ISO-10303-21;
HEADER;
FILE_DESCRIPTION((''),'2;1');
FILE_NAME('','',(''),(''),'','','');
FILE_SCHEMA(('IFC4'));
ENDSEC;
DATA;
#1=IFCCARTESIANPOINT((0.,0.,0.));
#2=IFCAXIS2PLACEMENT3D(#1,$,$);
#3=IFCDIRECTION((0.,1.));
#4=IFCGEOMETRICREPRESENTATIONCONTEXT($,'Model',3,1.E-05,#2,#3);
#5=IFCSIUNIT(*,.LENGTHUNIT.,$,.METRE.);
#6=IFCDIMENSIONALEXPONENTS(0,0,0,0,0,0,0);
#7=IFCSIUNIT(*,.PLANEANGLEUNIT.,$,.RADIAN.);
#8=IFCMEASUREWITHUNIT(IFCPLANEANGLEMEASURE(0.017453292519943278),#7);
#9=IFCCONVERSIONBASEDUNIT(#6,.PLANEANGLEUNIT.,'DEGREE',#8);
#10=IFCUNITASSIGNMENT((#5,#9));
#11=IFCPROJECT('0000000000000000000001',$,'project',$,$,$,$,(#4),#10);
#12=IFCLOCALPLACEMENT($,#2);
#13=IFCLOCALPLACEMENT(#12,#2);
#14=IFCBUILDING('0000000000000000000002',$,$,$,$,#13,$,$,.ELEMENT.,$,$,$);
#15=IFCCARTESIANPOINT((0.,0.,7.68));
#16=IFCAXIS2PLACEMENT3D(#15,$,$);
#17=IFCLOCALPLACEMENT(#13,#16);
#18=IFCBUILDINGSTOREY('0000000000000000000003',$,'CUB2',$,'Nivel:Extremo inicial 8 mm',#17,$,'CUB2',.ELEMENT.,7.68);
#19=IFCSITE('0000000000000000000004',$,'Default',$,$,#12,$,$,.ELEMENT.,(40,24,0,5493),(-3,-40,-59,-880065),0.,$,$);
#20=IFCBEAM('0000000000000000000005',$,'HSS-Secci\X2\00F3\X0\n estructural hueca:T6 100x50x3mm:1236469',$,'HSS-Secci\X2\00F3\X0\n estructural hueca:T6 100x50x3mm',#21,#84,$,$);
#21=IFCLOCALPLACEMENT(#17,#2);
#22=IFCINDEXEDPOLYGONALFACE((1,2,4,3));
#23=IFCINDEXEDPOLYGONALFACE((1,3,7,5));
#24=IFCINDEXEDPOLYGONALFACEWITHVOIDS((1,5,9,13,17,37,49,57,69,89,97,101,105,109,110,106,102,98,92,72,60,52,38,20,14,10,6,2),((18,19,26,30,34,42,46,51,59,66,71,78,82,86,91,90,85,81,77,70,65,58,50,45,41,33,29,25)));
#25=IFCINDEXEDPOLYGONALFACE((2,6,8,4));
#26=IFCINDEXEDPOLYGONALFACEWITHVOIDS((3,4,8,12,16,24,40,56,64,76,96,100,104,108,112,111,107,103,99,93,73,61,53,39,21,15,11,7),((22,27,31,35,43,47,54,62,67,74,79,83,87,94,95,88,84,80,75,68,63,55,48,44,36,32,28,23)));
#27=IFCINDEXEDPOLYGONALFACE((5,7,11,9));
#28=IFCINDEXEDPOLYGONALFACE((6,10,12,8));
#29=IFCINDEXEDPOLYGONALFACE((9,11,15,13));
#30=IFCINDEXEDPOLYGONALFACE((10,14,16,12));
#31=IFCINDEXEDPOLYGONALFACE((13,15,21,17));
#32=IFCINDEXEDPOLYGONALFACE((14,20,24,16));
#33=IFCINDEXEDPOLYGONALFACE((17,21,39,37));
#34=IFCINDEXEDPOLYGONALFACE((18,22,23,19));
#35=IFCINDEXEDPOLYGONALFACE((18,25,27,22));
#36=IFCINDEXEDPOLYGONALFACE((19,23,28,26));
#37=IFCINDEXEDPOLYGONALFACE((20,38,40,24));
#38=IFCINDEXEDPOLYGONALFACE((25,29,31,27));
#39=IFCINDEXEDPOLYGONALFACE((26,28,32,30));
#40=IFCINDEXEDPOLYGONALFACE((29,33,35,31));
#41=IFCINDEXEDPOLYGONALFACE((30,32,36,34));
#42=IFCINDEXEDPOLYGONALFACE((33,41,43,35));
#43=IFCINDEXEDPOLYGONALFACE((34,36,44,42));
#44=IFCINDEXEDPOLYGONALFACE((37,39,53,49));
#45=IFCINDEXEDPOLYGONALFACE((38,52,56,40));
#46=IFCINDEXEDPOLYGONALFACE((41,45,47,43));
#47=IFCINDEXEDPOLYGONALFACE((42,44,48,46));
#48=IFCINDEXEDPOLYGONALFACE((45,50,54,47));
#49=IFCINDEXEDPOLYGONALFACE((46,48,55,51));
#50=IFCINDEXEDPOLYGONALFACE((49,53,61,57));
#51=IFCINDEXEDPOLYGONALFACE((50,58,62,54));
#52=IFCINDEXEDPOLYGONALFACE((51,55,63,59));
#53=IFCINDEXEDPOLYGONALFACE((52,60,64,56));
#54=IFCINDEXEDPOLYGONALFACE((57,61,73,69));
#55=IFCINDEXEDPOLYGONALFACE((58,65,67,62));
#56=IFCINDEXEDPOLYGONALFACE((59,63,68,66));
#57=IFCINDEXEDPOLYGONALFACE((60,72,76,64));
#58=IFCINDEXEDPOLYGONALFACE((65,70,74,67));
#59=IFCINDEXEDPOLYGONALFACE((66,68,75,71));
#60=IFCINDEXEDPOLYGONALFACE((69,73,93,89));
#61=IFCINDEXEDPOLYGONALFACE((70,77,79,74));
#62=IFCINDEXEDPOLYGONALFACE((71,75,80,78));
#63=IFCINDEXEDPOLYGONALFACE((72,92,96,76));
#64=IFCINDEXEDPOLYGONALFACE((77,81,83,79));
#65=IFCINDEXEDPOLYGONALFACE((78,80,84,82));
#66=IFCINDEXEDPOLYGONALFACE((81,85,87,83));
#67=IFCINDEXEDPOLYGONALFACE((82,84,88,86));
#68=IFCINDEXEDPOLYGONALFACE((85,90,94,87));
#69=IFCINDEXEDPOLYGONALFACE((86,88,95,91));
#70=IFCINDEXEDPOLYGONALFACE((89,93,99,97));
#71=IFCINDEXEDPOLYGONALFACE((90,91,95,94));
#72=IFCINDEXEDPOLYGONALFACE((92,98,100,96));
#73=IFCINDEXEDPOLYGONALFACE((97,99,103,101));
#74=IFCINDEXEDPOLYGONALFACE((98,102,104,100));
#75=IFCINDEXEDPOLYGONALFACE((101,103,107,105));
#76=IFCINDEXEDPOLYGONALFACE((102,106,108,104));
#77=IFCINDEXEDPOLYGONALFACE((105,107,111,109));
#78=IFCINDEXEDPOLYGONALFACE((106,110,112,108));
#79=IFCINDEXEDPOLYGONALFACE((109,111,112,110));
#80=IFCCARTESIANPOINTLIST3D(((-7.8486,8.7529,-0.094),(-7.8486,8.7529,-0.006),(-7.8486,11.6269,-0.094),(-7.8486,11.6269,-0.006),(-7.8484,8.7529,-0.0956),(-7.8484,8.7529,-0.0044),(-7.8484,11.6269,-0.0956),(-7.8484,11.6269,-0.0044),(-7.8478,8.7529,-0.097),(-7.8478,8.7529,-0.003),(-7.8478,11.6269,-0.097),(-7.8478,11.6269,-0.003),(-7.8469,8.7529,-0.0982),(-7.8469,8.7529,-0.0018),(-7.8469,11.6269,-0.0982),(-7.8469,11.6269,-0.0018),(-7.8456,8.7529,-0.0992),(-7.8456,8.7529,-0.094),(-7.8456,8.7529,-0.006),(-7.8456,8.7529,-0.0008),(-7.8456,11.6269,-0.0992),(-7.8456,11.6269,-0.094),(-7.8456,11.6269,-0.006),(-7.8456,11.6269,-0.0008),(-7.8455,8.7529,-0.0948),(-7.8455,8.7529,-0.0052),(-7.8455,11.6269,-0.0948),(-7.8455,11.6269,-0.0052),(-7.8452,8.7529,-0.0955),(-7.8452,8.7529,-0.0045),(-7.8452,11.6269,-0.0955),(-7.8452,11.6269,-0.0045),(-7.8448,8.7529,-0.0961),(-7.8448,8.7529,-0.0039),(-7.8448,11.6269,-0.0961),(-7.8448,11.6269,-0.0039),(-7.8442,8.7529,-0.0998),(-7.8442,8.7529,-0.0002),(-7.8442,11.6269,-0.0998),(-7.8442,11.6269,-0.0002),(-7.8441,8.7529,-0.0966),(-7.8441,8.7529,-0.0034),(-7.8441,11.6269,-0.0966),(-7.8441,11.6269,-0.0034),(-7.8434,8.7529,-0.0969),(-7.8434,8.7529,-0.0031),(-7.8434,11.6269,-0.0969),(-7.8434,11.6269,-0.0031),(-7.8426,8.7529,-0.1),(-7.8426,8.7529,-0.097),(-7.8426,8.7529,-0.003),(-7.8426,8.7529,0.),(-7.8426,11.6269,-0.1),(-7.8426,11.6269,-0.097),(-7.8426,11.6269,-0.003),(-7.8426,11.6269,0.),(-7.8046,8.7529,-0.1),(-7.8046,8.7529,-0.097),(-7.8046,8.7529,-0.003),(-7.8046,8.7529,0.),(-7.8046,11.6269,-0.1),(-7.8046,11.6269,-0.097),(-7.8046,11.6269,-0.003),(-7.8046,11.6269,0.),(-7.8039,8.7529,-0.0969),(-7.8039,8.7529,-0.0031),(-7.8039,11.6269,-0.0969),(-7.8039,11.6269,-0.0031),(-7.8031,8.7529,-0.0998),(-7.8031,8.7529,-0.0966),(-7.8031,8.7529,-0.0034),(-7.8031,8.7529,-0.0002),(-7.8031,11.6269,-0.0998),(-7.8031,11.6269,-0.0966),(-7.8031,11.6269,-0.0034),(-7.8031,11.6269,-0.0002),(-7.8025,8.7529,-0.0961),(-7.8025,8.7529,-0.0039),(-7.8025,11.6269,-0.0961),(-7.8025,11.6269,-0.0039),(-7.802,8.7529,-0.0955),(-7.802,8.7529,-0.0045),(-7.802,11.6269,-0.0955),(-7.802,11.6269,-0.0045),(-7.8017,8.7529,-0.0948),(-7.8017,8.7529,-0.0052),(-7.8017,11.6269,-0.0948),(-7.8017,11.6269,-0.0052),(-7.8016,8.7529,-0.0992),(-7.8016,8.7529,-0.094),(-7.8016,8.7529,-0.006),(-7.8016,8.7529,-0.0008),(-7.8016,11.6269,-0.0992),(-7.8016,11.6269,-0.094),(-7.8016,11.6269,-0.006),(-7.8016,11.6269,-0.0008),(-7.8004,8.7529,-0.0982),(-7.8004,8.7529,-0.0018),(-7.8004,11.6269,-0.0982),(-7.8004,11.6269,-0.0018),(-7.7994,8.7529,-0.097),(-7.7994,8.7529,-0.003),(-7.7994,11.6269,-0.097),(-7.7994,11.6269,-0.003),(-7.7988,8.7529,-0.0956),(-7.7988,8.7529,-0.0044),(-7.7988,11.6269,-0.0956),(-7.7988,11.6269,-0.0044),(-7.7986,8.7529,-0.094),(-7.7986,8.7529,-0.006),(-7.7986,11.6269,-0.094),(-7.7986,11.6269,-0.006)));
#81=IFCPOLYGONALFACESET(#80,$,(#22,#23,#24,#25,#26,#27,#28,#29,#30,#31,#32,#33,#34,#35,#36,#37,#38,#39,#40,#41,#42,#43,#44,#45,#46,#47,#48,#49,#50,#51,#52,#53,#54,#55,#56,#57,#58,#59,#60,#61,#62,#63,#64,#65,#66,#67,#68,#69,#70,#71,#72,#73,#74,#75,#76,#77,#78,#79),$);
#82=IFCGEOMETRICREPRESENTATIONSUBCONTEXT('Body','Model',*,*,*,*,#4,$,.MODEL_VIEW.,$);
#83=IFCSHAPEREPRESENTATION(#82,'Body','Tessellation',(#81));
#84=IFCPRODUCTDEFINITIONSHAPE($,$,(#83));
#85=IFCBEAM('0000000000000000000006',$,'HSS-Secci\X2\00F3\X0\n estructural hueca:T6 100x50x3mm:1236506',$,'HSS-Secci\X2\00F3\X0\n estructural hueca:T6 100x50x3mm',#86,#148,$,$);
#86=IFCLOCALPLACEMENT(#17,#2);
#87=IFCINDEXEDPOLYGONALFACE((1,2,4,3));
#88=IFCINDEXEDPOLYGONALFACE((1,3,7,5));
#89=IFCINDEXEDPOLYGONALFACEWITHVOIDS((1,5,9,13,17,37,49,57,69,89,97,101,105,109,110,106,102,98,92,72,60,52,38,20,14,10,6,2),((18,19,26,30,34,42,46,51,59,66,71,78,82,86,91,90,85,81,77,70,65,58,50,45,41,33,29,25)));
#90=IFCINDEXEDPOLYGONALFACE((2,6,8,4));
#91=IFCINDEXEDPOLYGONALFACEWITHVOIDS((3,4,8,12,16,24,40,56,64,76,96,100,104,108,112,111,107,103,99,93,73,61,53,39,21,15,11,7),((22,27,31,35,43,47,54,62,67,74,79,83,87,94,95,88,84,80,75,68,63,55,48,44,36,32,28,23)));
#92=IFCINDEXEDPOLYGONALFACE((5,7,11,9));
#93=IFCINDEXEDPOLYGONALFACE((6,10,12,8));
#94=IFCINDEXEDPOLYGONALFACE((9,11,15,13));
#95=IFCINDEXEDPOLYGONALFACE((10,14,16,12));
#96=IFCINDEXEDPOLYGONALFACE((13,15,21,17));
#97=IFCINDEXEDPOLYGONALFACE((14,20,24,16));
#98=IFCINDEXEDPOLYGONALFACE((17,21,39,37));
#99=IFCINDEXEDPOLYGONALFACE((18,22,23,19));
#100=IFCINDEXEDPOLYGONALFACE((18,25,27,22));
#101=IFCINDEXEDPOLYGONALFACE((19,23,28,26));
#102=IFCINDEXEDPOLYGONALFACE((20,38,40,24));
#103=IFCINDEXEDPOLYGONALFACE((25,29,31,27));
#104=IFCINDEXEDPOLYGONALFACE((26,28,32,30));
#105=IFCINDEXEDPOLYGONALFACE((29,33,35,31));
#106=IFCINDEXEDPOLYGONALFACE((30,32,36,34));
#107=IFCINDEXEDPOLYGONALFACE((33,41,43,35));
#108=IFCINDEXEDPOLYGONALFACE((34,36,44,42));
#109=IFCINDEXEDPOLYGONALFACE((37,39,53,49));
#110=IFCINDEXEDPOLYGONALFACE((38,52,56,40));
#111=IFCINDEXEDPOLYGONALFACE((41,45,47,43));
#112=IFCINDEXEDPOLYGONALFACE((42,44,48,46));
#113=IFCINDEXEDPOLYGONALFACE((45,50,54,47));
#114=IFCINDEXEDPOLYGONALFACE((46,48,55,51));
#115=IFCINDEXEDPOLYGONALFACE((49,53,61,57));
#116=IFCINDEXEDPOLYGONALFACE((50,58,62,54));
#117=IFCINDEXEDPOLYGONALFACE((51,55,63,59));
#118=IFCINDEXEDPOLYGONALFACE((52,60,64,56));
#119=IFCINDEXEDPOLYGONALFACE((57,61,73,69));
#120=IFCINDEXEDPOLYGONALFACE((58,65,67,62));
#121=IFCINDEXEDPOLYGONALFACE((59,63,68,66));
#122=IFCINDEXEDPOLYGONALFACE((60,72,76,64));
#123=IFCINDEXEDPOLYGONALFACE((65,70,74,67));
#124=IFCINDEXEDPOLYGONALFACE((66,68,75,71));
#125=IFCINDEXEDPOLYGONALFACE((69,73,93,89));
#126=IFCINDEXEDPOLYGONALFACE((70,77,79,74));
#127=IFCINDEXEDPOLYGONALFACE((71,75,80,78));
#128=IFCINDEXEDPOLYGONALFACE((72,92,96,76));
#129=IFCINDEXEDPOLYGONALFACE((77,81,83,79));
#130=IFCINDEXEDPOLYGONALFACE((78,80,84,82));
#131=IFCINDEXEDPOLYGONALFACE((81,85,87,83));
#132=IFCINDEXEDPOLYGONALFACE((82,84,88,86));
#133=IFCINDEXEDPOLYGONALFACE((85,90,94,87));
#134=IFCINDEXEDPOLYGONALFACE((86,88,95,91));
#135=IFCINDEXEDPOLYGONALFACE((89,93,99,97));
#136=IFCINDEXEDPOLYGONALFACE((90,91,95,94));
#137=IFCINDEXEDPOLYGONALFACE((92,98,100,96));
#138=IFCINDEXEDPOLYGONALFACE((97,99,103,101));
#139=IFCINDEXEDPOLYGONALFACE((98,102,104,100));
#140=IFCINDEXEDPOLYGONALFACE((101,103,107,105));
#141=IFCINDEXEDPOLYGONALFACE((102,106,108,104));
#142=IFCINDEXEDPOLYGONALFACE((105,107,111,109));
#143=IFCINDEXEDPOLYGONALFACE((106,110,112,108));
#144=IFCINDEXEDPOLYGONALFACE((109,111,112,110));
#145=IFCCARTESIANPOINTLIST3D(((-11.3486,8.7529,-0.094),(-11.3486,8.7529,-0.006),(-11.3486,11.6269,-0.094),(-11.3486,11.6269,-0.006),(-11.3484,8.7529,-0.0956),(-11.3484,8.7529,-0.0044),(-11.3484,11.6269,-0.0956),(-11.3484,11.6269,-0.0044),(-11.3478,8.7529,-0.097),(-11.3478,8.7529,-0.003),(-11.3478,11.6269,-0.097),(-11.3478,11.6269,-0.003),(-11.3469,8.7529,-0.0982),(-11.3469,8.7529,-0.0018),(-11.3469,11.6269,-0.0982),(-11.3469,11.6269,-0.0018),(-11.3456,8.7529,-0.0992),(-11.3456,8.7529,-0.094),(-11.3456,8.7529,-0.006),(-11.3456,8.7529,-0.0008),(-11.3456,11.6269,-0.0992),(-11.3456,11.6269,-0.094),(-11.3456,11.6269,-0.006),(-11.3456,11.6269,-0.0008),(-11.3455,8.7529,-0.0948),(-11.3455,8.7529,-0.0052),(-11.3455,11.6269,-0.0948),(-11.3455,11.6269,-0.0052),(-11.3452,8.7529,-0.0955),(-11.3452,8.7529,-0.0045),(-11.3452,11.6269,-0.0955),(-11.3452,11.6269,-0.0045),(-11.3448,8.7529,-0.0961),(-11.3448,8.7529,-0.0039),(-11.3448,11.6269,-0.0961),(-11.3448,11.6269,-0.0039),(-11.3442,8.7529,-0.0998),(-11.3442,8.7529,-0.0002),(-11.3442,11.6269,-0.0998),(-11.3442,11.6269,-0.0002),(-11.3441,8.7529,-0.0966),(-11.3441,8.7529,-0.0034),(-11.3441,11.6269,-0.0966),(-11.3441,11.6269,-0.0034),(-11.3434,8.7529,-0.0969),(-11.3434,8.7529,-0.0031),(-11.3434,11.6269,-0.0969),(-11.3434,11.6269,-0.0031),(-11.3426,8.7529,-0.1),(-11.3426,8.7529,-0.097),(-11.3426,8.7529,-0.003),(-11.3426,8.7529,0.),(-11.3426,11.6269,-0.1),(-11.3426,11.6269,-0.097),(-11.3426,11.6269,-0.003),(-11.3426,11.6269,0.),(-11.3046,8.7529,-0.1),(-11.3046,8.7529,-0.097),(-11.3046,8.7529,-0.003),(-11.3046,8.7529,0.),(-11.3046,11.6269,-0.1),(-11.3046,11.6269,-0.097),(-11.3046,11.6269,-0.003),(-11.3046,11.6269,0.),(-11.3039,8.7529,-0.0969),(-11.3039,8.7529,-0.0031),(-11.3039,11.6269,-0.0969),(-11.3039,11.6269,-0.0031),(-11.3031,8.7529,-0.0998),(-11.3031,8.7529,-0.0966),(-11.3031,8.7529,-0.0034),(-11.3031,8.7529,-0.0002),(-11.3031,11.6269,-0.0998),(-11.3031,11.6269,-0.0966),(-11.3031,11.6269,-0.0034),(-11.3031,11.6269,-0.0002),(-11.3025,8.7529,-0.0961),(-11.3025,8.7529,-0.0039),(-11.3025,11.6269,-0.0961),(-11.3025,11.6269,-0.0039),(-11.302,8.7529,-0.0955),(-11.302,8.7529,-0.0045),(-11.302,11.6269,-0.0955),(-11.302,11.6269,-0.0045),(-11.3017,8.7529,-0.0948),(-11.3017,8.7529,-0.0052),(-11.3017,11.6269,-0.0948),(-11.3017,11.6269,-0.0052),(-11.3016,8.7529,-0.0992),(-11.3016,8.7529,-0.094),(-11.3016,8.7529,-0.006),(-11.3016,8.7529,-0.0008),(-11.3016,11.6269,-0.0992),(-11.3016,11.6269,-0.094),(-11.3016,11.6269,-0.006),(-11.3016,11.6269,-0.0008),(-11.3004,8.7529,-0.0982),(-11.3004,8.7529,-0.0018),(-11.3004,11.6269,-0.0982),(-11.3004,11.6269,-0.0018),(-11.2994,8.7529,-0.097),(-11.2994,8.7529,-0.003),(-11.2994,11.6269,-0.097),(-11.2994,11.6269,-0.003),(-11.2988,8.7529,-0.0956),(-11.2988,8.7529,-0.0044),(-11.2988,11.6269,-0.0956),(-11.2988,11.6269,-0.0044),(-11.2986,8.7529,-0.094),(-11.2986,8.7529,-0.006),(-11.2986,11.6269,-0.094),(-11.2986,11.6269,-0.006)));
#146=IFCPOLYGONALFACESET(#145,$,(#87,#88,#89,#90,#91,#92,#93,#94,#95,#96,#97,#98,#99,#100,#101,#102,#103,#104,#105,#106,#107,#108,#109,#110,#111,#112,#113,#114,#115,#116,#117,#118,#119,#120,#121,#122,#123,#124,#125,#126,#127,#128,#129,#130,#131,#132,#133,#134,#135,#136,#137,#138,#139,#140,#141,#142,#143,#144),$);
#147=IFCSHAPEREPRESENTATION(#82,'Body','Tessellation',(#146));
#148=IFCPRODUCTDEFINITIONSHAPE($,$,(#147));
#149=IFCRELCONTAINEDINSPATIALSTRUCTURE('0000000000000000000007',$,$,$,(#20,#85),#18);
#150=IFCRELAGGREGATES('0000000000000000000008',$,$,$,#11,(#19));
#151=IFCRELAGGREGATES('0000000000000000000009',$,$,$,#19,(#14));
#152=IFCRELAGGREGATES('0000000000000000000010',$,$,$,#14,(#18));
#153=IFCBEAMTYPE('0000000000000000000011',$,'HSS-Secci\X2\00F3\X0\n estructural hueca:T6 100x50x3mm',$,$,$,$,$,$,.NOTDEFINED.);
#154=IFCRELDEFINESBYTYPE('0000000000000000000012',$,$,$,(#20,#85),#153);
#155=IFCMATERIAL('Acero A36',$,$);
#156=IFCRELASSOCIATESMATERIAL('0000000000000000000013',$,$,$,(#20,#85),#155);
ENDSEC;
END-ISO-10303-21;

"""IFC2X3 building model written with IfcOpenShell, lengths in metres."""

from ifc_helpers import new_model, entity, si_unit, converted_unit, direction, frame, frame_2d, origin, place, context, subcontext, project, spatial, polyline, circle_curve, parameter, trimmed, segment, composite_curve, outline, extrude, material, type_object, element, save


model = new_model("IFC2X3")

# Units and contexts
model_context = context("Model", 3, precision=1e-05, world=origin(), true_north=direction((0.0, 1.0)))
body_context = subcontext(model_context, "Body", "Model", "MODEL_VIEW")
ifc_project = project(units=[si_unit("LENGTHUNIT", "METRE"), converted_unit("PLANEANGLEUNIT", "DEGREE", entity("IfcPlaneAngleMeasure", 0.017453292519943278), si_unit("PLANEANGLEUNIT", "RADIAN"), dimensions=[0, 0, 0, 0, 0, 0, 0])], contexts=[model_context])

# Site, building, storey
site_placement = place(None, origin())
site = spatial("IfcSite", under=ifc_project, at=site_placement, Name="Default", CompositionType="ELEMENT", RefLatitude=(40, 24, 0, 5493), RefLongitude=(-3, -40, -59, -880065), RefElevation=0.0)
building_placement = place(site_placement, origin())
building = spatial("IfcBuilding", under=site, at=building_placement, CompositionType="ELEMENT")
storey_placement = place(building_placement, frame((0.0, 0.0, 7.68)))
storey = spatial("IfcBuildingStorey", under=building, at=storey_placement, Name="CUB2", ObjectType="Nivel:Extremo inicial 8 mm", LongName="CUB2", CompositionType="ELEMENT", Elevation=7.68)

# Beams
ifc_material = material(Name="Acero A36")
beam_type_1 = type_object("IfcBeamType", Name="HSS-Sección estructural hueca:T6 100x50x3mm", PredefinedType="NOTDEFINED")
beam_1_placement = place(storey_placement, frame((-7.8236, 11.7899, 0.0), z_axis=(0.0, 0.0, 1.0), x_axis=(0.0, -1.0, 0.0)))
element("IfcBeam", 1, at=beam_1_placement, inside=storey, type_object=beam_type_1, material=ifc_material, Name="HSS-Sección estructural hueca:T6 100x50x3mm:1236469", ObjectType="HSS-Sección estructural hueca:T6 100x50x3mm", context=body_context, shape_type="SweptSolid", body=[
    extrude(outline(composite_curve([segment(trimmed(circle_curve(frame_2d((-0.019, -0.044), x_axis=(1.0, 0.0)), 0.006), [parameter(180.0)], [parameter(270.0)], True, "PARAMETER"), True, "CONTINUOUS"), segment(polyline([(-0.019, -0.05), (0.019, -0.05)]), True, "CONTINUOUS"), segment(trimmed(circle_curve(frame_2d((0.019, -0.044), x_axis=(1.0, 0.0)), 0.006), [parameter(270.0)], [parameter(0.0)], True, "PARAMETER"), True, "CONTINUOUS"), segment(polyline([(0.025, -0.044), (0.025, 0.044)]), True, "CONTINUOUS"), segment(trimmed(circle_curve(frame_2d((0.019, 0.044), x_axis=(1.0, 0.0)), 0.006), [parameter(360.0)], [parameter(90.0)], True, "PARAMETER"), True, "CONTINUOUS"), segment(polyline([(0.019, 0.05), (-0.019, 0.05)]), True, "CONTINUOUS"), segment(trimmed(circle_curve(frame_2d((-0.019, 0.044), x_axis=(1.0, 0.0)), 0.006), [parameter(90.0)], [parameter(180.0)], True, "PARAMETER"), True, "CONTINUOUS"), segment(polyline([(-0.025, 0.044), (-0.025, -0.044)]), True, "CONTINUOUS")], self_intersect=False), holes=[composite_curve([segment(polyline([(0.019, -0.047), (-0.019, -0.047)]), True, "CONTINUOUS"), segment(trimmed(circle_curve(frame_2d((-0.019, -0.044), x_axis=(1.0, 0.0)), 0.003), [parameter(180.0)], [parameter(270.0)], True, "PARAMETER"), False, "CONTINUOUS"), segment(polyline([(-0.022, -0.044), (-0.022, 0.044)]), True, "CONTINUOUS"), segment(trimmed(circle_curve(frame_2d((-0.019, 0.044), x_axis=(1.0, 0.0)), 0.003), [parameter(90.0)], [parameter(180.0)], True, "PARAMETER"), False, "CONTINUOUS"), segment(polyline([(-0.019, 0.047), (0.019, 0.047)]), True, "CONTINUOUS"), segment(trimmed(circle_curve(frame_2d((0.019, 0.044), x_axis=(1.0, 0.0)), 0.003), [parameter(0.0)], [parameter(90.0)], True, "PARAMETER"), False, "CONTINUOUS"), segment(polyline([(0.022, 0.044), (0.022, -0.044)]), True, "CONTINUOUS"), segment(trimmed(circle_curve(frame_2d((0.019, -0.044), x_axis=(1.0, 0.0)), 0.003), [parameter(270.0)], [parameter(0.0)], True, "PARAMETER"), False, "CONTINUOUS")], self_intersect=False)]), frame((0.163, 0.0, -0.05), z_axis=(1.0, 0.0, 0.0), x_axis=(0.0, -1.0, 0.0)), (0.0, 0.0, 1.0), 2.874),
])
beam_2_placement = place(storey_placement, frame((-11.3236, 11.7899, 0.0), z_axis=(0.0, 0.0, 1.0), x_axis=(0.0, -1.0, 0.0)))
element("IfcBeam", 2, at=beam_2_placement, inside=storey, type_object=beam_type_1, material=ifc_material, Name="HSS-Sección estructural hueca:T6 100x50x3mm:1236506", ObjectType="HSS-Sección estructural hueca:T6 100x50x3mm", context=body_context, shape_type="SweptSolid", body=[
    extrude(outline(composite_curve([segment(trimmed(circle_curve(frame_2d((-0.019, -0.044), x_axis=(1.0, 0.0)), 0.006), [parameter(180.0)], [parameter(270.0)], True, "PARAMETER"), True, "CONTINUOUS"), segment(polyline([(-0.019, -0.05), (0.019, -0.05)]), True, "CONTINUOUS"), segment(trimmed(circle_curve(frame_2d((0.019, -0.044), x_axis=(1.0, 0.0)), 0.006), [parameter(270.0)], [parameter(0.0)], True, "PARAMETER"), True, "CONTINUOUS"), segment(polyline([(0.025, -0.044), (0.025, 0.044)]), True, "CONTINUOUS"), segment(trimmed(circle_curve(frame_2d((0.019, 0.044), x_axis=(1.0, 0.0)), 0.006), [parameter(360.0)], [parameter(90.0)], True, "PARAMETER"), True, "CONTINUOUS"), segment(polyline([(0.019, 0.05), (-0.019, 0.05)]), True, "CONTINUOUS"), segment(trimmed(circle_curve(frame_2d((-0.019, 0.044), x_axis=(1.0, 0.0)), 0.006), [parameter(90.0)], [parameter(180.0)], True, "PARAMETER"), True, "CONTINUOUS"), segment(polyline([(-0.025, 0.044), (-0.025, -0.044)]), True, "CONTINUOUS")], self_intersect=False), holes=[composite_curve([segment(polyline([(0.019, -0.047), (-0.019, -0.047)]), True, "CONTINUOUS"), segment(trimmed(circle_curve(frame_2d((-0.019, -0.044), x_axis=(1.0, 0.0)), 0.003), [parameter(180.0)], [parameter(270.0)], True, "PARAMETER"), False, "CONTINUOUS"), segment(polyline([(-0.022, -0.044), (-0.022, 0.044)]), True, "CONTINUOUS"), segment(trimmed(circle_curve(frame_2d((-0.019, 0.044), x_axis=(1.0, 0.0)), 0.003), [parameter(90.0)], [parameter(180.0)], True, "PARAMETER"), False, "CONTINUOUS"), segment(polyline([(-0.019, 0.047), (0.019, 0.047)]), True, "CONTINUOUS"), segment(trimmed(circle_curve(frame_2d((0.019, 0.044), x_axis=(1.0, 0.0)), 0.003), [parameter(0.0)], [parameter(90.0)], True, "PARAMETER"), False, "CONTINUOUS"), segment(polyline([(0.022, 0.044), (0.022, -0.044)]), True, "CONTINUOUS"), segment(trimmed(circle_curve(frame_2d((0.019, -0.044), x_axis=(1.0, 0.0)), 0.003), [parameter(270.0)], [parameter(0.0)], True, "PARAMETER"), False, "CONTINUOUS")], self_intersect=False)]), frame((0.163, 0.0, -0.05), z_axis=(1.0, 0.0, 0.0), x_axis=(0.0, -1.0, 0.0)), (0.0, 0.0, 1.0), 2.874),
])

save(model, "model.ifc")
